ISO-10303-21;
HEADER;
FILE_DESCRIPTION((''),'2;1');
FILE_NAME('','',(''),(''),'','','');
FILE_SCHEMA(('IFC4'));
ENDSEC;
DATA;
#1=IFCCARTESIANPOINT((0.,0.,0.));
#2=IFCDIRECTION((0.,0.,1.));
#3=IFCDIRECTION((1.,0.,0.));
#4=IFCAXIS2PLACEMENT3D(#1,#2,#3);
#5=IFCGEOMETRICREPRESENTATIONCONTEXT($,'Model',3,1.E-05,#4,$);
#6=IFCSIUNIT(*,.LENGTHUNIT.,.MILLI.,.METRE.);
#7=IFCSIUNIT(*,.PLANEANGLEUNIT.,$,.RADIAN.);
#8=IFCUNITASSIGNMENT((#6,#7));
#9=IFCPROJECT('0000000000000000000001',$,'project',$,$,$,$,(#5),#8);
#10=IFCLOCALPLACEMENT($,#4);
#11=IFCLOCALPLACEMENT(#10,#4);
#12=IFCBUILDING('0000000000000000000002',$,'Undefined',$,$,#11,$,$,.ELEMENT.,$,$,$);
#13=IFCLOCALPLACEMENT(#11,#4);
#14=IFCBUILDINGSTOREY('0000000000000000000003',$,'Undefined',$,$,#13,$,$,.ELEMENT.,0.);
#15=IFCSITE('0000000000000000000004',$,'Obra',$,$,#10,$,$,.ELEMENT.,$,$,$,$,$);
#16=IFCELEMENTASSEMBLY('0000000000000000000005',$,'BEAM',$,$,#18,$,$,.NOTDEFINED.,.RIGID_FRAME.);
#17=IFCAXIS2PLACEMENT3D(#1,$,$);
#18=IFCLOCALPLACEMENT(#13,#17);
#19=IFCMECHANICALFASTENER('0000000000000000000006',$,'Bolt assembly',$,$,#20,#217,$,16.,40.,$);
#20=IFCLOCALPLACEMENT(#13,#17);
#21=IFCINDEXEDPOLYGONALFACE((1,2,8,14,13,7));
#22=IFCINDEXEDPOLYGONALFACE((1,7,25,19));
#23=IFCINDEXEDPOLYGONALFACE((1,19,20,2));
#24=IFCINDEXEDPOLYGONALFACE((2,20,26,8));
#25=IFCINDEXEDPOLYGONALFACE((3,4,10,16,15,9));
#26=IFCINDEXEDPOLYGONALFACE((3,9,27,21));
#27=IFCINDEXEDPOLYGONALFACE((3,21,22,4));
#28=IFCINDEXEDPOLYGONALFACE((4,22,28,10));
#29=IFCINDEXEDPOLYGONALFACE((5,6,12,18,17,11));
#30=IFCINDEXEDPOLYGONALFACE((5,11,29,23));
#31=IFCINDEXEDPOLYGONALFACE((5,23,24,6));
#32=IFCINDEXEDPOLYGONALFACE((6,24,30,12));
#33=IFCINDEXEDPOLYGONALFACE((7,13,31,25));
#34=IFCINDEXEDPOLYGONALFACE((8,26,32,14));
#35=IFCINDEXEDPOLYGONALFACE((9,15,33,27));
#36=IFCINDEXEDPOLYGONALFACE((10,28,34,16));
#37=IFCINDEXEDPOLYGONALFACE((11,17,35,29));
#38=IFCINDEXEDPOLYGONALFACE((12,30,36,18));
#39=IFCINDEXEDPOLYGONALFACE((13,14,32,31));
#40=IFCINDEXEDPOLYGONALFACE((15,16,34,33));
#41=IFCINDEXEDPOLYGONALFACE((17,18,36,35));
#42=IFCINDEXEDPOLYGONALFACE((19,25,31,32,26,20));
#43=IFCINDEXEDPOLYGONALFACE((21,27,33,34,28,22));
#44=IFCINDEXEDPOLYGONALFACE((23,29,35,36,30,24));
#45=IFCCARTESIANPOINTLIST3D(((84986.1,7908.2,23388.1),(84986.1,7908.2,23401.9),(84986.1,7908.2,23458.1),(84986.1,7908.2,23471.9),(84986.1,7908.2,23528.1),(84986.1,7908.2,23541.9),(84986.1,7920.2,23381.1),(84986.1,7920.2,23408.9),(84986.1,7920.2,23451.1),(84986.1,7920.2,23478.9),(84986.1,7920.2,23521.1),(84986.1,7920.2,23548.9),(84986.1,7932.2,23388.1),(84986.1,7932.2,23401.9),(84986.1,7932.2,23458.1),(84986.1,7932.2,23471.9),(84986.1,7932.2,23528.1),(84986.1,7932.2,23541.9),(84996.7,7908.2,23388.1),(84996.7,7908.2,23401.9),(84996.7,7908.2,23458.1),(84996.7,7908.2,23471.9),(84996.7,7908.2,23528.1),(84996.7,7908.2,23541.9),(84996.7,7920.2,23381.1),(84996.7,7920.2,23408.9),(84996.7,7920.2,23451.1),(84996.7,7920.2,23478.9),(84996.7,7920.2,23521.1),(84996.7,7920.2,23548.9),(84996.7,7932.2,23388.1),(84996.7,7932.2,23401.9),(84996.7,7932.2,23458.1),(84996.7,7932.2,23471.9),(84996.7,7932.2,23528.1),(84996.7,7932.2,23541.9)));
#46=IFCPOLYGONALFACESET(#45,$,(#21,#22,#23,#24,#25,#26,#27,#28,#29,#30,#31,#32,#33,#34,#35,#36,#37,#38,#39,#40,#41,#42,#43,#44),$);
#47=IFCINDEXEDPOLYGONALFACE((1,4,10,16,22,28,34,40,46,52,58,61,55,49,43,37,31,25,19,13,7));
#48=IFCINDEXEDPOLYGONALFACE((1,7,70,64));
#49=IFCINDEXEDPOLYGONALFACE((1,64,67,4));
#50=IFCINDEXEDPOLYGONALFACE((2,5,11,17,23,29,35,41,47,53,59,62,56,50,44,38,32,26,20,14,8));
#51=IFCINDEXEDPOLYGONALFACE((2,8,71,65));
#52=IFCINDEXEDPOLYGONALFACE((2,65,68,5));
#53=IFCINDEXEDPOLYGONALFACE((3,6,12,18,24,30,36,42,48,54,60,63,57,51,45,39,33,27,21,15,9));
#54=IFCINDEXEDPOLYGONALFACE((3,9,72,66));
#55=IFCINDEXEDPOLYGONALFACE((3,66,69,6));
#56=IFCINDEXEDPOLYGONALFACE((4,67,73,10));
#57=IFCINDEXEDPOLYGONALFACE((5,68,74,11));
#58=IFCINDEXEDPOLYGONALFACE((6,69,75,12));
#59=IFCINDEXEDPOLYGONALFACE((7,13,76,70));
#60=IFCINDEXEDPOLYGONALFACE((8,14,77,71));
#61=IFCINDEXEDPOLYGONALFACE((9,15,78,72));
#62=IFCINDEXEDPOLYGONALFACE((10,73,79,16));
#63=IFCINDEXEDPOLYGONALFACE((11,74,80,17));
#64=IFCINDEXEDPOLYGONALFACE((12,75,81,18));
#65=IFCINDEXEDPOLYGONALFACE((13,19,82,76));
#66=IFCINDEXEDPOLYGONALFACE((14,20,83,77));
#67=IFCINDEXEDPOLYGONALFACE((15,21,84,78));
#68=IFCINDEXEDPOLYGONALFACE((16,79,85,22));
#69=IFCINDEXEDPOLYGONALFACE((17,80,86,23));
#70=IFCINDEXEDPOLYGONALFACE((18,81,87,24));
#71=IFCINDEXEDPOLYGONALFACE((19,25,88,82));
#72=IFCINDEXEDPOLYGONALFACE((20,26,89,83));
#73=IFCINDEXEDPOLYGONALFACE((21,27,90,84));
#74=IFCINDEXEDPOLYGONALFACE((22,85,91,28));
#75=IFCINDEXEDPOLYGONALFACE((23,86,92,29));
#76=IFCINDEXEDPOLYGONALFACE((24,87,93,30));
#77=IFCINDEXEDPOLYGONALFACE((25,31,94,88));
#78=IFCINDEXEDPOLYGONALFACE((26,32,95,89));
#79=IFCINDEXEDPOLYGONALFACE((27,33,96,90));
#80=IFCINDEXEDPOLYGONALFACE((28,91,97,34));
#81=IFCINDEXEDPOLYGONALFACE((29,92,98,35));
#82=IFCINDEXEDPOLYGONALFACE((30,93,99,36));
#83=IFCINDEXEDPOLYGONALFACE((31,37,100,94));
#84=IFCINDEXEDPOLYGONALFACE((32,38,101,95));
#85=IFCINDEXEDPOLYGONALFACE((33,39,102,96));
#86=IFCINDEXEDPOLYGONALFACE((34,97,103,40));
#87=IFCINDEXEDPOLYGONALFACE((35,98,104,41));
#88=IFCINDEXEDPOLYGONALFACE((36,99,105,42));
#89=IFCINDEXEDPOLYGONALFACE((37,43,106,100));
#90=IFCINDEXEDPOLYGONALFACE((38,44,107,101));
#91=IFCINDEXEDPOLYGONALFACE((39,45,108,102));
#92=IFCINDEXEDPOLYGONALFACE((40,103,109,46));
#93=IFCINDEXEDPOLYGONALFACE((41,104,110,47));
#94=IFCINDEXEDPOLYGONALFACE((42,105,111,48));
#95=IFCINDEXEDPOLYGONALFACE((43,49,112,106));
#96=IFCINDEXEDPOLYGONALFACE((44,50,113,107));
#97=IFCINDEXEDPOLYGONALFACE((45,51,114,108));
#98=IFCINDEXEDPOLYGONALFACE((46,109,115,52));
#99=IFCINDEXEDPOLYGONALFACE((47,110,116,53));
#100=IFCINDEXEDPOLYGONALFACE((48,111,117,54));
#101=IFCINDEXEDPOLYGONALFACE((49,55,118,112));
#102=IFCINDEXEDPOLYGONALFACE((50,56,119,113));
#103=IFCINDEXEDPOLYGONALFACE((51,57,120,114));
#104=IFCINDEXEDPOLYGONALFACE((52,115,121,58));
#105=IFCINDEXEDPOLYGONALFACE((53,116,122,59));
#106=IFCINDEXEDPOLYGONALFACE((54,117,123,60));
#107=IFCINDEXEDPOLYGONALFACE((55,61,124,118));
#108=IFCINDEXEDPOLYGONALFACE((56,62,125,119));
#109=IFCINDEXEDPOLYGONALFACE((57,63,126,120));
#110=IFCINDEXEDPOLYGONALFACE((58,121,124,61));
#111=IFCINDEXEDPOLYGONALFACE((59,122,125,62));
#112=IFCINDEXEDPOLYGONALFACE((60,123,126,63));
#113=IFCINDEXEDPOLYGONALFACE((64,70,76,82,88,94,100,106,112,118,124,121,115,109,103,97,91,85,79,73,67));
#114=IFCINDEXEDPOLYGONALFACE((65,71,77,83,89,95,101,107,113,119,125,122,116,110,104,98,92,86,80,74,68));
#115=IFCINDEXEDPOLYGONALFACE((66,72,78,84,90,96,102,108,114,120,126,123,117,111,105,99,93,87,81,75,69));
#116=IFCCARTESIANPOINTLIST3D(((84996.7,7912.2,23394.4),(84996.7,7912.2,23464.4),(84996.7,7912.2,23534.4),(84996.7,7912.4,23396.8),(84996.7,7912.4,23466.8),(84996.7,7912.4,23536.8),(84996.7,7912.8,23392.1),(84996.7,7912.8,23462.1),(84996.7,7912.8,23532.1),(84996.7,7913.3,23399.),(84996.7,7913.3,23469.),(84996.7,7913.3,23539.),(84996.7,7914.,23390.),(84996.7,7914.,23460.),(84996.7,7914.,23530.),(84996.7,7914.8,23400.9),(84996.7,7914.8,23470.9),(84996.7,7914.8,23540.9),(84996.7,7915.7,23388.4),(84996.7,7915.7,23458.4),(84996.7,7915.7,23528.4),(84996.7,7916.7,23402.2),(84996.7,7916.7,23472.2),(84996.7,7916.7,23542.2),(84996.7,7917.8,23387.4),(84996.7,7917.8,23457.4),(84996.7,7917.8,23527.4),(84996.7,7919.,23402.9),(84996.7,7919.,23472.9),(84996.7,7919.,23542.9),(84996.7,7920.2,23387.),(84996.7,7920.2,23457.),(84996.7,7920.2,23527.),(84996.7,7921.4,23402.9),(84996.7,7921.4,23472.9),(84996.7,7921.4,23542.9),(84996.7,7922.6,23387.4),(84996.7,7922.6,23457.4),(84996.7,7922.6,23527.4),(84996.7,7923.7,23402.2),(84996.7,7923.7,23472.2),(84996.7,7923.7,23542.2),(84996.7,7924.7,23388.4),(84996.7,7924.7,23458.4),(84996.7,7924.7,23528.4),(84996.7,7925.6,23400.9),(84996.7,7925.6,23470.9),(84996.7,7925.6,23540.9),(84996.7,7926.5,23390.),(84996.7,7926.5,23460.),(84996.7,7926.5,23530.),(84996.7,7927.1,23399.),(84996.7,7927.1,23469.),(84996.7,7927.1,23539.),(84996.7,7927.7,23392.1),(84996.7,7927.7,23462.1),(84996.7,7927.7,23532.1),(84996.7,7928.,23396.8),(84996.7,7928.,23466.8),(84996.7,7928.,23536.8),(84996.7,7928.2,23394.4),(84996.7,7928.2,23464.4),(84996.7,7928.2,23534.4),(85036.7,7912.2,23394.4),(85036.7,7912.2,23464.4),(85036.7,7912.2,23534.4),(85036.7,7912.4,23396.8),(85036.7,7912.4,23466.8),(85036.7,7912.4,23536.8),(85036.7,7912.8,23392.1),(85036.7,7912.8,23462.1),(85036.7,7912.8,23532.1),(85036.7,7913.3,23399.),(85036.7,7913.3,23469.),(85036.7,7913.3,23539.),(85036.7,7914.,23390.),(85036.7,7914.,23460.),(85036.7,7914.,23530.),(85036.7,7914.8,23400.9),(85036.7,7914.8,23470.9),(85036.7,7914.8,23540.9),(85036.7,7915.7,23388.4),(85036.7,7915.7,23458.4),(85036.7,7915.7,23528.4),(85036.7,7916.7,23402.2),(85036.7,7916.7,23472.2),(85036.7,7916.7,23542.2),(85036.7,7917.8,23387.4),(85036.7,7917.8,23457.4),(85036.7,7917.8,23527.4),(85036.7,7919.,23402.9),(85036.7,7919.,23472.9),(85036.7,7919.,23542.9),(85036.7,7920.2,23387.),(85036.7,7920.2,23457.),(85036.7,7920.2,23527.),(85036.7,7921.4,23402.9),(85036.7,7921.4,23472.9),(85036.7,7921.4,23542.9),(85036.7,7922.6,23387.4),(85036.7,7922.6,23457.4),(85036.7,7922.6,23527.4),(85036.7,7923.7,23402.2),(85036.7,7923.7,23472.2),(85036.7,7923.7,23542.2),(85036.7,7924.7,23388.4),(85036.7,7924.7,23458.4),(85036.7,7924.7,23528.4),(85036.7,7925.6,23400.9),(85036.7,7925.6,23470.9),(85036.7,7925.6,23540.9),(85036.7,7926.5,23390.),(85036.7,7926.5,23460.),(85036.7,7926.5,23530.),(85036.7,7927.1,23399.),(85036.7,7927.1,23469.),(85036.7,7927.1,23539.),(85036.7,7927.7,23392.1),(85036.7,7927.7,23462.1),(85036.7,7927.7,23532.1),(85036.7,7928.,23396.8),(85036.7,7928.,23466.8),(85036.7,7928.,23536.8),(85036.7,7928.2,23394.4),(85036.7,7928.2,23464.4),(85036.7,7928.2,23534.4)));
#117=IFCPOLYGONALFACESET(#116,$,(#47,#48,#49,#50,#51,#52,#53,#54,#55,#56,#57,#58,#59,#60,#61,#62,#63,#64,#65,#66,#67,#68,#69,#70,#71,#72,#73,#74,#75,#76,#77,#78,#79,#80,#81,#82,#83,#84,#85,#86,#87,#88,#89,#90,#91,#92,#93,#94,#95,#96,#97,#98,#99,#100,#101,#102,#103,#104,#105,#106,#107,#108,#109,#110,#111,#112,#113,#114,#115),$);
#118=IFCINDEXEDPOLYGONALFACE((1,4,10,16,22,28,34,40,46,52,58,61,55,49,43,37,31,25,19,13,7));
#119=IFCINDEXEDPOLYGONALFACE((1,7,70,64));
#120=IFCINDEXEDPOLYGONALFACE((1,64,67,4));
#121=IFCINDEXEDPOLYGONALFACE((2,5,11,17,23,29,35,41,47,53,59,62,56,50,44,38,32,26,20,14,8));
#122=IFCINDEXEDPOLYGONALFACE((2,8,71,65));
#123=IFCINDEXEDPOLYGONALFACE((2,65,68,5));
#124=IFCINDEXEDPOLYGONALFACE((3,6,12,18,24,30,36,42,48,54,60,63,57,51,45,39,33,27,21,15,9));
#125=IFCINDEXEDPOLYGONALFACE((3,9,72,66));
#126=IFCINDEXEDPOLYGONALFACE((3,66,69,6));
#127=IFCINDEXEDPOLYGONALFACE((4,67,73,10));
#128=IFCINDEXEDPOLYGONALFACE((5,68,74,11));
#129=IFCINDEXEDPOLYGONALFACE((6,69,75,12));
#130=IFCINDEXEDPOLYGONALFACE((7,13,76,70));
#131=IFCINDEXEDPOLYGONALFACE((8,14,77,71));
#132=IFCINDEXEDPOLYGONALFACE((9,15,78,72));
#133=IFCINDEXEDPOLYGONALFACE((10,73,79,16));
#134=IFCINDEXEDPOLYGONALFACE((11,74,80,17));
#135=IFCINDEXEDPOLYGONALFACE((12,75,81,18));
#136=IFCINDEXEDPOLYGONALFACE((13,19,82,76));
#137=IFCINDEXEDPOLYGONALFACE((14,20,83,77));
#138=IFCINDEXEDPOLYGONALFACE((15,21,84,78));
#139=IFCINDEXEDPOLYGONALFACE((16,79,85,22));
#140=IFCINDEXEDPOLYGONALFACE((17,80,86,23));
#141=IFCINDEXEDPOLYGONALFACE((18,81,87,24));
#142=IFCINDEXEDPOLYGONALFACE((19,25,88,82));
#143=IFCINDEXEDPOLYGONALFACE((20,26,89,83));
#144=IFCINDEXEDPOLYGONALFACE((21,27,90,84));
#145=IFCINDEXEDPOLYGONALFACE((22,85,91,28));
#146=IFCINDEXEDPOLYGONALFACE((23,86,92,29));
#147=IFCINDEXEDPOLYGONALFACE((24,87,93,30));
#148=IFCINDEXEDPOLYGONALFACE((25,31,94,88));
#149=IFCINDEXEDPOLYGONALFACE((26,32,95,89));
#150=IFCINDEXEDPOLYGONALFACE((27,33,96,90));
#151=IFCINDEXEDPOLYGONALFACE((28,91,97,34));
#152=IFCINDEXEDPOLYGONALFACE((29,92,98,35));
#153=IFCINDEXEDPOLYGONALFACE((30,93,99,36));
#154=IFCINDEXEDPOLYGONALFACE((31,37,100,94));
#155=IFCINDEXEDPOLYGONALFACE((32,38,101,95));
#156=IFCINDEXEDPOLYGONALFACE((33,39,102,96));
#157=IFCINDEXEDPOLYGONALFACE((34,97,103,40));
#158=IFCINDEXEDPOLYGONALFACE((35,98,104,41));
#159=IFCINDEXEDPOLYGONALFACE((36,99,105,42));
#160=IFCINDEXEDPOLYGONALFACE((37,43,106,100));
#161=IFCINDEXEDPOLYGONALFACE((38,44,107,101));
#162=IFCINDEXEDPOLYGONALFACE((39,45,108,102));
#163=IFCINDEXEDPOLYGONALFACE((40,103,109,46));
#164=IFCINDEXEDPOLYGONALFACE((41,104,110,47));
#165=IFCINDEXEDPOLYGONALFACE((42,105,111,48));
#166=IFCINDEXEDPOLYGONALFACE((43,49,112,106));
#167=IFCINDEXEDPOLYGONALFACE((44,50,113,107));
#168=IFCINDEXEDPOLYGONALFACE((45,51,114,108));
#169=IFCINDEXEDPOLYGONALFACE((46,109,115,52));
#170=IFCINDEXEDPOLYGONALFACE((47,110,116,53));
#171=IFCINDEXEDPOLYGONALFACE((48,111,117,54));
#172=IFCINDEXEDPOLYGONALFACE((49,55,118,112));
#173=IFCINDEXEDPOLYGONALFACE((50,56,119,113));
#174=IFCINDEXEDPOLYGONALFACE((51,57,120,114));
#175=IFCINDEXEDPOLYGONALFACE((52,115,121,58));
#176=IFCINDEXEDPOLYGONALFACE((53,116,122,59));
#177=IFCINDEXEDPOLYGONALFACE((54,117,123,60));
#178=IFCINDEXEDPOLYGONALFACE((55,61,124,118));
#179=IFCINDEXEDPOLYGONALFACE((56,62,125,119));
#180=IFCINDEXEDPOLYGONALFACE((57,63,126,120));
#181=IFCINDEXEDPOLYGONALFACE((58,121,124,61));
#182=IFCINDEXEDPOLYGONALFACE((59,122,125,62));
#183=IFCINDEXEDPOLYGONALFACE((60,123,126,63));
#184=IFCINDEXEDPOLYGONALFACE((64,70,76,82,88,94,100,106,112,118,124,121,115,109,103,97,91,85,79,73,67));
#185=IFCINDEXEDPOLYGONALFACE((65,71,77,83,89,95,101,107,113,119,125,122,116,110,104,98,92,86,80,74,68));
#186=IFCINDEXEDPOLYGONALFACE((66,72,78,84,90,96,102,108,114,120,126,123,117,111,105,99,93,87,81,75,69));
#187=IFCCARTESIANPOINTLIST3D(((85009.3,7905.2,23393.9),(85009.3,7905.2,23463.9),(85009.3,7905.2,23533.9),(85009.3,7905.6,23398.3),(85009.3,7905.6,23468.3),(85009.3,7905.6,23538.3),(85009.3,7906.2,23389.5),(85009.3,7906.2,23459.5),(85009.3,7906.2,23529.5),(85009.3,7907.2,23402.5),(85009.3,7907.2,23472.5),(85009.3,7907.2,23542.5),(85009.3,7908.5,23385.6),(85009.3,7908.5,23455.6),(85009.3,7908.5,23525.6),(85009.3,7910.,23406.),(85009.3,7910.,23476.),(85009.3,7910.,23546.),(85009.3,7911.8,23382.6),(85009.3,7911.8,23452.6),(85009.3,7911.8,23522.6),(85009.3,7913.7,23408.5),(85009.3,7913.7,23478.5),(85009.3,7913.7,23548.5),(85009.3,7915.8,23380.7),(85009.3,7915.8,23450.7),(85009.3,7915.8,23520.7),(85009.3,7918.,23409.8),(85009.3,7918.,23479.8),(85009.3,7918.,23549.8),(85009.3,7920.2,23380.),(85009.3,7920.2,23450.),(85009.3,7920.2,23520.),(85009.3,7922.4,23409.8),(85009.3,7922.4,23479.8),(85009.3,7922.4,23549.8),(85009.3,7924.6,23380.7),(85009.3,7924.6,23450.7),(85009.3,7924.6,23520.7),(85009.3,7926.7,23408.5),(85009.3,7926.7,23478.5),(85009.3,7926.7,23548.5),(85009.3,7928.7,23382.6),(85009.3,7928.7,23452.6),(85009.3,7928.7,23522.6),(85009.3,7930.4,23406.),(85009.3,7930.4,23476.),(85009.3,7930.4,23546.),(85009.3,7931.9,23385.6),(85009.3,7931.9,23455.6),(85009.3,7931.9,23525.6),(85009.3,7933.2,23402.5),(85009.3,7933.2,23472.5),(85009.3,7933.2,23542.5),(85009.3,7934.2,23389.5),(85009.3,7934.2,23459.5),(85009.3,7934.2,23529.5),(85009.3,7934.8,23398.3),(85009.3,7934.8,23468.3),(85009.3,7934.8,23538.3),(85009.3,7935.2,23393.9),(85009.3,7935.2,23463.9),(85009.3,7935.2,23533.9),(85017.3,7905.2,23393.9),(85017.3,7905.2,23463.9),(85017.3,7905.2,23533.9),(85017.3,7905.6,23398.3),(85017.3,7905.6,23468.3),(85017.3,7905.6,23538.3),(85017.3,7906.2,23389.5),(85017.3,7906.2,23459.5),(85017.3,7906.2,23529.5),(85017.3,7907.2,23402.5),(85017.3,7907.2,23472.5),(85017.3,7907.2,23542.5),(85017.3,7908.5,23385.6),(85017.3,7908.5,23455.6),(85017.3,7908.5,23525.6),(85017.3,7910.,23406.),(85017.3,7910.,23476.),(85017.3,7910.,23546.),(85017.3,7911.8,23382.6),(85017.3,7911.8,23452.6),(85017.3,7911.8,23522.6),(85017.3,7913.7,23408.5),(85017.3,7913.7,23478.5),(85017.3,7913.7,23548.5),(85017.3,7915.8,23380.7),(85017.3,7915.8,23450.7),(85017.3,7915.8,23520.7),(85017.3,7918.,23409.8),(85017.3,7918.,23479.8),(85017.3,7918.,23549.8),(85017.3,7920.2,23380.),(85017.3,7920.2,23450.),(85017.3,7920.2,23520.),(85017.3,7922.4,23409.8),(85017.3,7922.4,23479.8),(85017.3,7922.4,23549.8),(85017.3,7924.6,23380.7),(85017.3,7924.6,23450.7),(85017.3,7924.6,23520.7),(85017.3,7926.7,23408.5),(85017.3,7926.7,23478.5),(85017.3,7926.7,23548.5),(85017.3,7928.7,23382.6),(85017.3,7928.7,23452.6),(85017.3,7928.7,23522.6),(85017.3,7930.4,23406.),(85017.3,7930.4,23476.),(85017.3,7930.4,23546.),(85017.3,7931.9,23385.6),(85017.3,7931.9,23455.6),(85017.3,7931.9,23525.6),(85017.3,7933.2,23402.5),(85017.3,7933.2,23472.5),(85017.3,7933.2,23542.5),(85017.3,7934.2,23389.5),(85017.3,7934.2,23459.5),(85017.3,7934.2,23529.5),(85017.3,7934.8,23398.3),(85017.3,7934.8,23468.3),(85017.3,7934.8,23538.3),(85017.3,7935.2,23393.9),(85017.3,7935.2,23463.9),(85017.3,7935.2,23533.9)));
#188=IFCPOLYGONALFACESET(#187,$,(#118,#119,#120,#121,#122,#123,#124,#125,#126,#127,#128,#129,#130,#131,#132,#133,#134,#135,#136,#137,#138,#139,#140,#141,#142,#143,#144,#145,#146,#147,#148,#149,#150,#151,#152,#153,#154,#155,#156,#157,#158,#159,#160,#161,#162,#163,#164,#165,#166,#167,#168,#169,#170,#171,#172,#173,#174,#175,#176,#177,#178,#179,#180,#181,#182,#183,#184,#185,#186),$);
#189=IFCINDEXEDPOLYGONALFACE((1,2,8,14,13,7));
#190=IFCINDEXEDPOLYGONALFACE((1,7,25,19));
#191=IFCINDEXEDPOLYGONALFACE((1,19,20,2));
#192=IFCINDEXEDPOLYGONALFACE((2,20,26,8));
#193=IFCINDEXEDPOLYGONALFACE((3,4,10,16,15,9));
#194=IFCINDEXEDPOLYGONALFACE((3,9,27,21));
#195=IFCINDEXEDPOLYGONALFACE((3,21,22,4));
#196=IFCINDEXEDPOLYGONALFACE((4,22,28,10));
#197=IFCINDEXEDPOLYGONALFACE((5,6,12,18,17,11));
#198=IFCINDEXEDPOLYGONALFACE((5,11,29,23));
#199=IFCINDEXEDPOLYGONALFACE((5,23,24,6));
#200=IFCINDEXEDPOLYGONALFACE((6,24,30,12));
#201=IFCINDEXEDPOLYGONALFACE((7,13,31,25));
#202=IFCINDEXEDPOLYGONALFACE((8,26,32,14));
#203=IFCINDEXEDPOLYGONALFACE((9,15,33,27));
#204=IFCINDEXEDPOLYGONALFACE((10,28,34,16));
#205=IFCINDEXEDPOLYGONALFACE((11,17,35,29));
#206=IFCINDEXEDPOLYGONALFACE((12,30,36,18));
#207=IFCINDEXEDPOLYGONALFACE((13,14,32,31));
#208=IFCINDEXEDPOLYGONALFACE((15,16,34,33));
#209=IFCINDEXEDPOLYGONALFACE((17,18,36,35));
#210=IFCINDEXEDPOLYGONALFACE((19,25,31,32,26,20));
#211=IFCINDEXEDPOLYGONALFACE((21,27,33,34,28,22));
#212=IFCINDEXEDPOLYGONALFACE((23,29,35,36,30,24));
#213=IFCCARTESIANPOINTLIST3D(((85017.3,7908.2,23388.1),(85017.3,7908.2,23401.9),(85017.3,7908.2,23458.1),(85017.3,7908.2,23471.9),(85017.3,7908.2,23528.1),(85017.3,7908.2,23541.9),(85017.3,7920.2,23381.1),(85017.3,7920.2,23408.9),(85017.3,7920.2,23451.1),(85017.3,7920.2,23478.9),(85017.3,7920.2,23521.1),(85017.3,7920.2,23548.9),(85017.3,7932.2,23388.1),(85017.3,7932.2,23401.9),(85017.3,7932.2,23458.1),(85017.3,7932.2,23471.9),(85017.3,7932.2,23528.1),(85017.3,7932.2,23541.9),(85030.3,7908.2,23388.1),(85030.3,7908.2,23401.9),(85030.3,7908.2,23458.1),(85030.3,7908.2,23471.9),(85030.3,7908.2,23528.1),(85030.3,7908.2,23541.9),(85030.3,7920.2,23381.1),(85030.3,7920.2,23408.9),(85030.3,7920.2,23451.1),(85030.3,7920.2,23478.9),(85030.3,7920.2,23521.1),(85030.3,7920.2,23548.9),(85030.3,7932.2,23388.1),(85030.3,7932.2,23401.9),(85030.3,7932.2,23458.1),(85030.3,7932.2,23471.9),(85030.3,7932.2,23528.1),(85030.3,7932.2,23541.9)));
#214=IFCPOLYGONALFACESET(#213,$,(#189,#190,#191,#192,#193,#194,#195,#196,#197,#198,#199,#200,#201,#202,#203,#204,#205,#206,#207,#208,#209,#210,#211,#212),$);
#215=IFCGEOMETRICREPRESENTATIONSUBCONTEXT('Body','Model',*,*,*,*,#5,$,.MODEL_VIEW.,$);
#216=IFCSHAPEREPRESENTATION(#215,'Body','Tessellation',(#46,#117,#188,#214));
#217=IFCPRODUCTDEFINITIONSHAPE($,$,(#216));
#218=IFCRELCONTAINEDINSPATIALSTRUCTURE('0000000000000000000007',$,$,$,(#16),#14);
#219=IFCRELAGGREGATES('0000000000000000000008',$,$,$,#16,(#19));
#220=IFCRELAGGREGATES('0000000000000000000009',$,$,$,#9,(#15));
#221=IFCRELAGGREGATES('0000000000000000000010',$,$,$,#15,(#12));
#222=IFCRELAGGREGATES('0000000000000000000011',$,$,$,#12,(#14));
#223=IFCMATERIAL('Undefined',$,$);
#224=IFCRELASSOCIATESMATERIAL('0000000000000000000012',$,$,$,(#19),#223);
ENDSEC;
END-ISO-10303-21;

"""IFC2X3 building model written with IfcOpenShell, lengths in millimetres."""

from ifc_helpers import new_model, si_unit, frame, origin_with_axes, origin_2d_with_axis, place, context, subcontext, project, spatial, polyline, circle, outline, extrude, source, transform, mapped, material, element, aggregate, save


model = new_model("IFC2X3")

# Units and contexts
model_context = context("Model", 3, precision=1e-05, world=origin_with_axes())
body_context = subcontext(model_context, "Body", "Model", "MODEL_VIEW")
ifc_project = project(units=[si_unit("LENGTHUNIT", "METRE", prefix="MILLI"), si_unit("PLANEANGLEUNIT", "RADIAN")], contexts=[model_context])

# Site, building, storey
site_placement = place(None, origin_with_axes())
site = spatial("IfcSite", under=ifc_project, at=site_placement, Name="Obra", CompositionType="ELEMENT")
building_placement = place(site_placement, origin_with_axes())
building = spatial("IfcBuilding", under=site, at=building_placement, Name="Undefined", CompositionType="ELEMENT")
storey_placement = place(building_placement, origin_with_axes())
storey = spatial("IfcBuildingStorey", under=building, at=storey_placement, Name="Undefined", CompositionType="ELEMENT", Elevation=0.0)

# Element assembly
assembly_1_placement = place(storey_placement, origin_with_axes())
assembly_1 = element("IfcElementAssembly", 1, at=assembly_1_placement, inside=storey, Name="BEAM", AssemblyPlace="NOTDEFINED", PredefinedType="RIGID_FRAME")

# Shared definitions
ifc_material_1 = material(Name="Undefined")

# Shared definitions
shared_shape_1 = source(origin_with_axes(), body_context, "Body", "SweptSolid", [
    extrude(outline(polyline([(13.9, 0.0), (6.9, 12.0), (-6.9, 12.0), (-13.9, 0.0), (-6.9, -12.0), (6.9, -12.0), (13.9, 0.0)])), frame((0.0, -13.9, 0.0), z_axis=(0.0, 1.0, 0.0), x_axis=(1.0, 0.0, 0.0)), (0.0, 0.0, 1.0), 10.6),
    extrude(circle(Radius=8.0, at=origin_2d_with_axis()), frame((0.0, -3.3, 0.0), z_axis=(0.0, 1.0, 0.0), x_axis=(1.0, 0.0, 0.0)), (0.0, 0.0, 1.0), 40.0),
    extrude(circle(Radius=15.0, at=origin_2d_with_axis()), frame((0.0, 9.3, 0.0), z_axis=(0.0, 1.0, 0.0), x_axis=(1.0, 0.0, 0.0)), (0.0, 0.0, 1.0), 8.0),
    extrude(outline(polyline([(13.9, 0.0), (6.9, 12.0), (-6.9, 12.0), (-13.9, 0.0), (-6.9, -12.0), (6.9, -12.0), (13.9, 0.0)])), frame((0.0, 17.3, 0.0), z_axis=(0.0, 1.0, 0.0), x_axis=(1.0, 0.0, 0.0)), (0.0, 0.0, 1.0), 13.0),
])

# Mechanical fastener
mechanical_fastener_1_placement = place(assembly_1_placement, frame((85000.0, 7960.2, 23570.0), z_axis=(0.0, -1.0, 0.0), x_axis=(0.0, 0.0, -1.0)))
mechanical_fastener_1 = element("IfcMechanicalFastener", 2, at=mechanical_fastener_1_placement, material=ifc_material_1, Name="Bolt assembly", NominalDiameter=16.0, NominalLength=40.0, context=body_context, shape_type="MappedRepresentation", body=[
    mapped(shared_shape_1, transform((35.0, 0.0, 40.0))),
    mapped(shared_shape_1, transform((105.0, 0.0, 40.0))),
    mapped(shared_shape_1, transform((175.0, 0.0, 40.0))),
])
aggregate(assembly_1, [mechanical_fastener_1])

save(model, "model.ifc")
